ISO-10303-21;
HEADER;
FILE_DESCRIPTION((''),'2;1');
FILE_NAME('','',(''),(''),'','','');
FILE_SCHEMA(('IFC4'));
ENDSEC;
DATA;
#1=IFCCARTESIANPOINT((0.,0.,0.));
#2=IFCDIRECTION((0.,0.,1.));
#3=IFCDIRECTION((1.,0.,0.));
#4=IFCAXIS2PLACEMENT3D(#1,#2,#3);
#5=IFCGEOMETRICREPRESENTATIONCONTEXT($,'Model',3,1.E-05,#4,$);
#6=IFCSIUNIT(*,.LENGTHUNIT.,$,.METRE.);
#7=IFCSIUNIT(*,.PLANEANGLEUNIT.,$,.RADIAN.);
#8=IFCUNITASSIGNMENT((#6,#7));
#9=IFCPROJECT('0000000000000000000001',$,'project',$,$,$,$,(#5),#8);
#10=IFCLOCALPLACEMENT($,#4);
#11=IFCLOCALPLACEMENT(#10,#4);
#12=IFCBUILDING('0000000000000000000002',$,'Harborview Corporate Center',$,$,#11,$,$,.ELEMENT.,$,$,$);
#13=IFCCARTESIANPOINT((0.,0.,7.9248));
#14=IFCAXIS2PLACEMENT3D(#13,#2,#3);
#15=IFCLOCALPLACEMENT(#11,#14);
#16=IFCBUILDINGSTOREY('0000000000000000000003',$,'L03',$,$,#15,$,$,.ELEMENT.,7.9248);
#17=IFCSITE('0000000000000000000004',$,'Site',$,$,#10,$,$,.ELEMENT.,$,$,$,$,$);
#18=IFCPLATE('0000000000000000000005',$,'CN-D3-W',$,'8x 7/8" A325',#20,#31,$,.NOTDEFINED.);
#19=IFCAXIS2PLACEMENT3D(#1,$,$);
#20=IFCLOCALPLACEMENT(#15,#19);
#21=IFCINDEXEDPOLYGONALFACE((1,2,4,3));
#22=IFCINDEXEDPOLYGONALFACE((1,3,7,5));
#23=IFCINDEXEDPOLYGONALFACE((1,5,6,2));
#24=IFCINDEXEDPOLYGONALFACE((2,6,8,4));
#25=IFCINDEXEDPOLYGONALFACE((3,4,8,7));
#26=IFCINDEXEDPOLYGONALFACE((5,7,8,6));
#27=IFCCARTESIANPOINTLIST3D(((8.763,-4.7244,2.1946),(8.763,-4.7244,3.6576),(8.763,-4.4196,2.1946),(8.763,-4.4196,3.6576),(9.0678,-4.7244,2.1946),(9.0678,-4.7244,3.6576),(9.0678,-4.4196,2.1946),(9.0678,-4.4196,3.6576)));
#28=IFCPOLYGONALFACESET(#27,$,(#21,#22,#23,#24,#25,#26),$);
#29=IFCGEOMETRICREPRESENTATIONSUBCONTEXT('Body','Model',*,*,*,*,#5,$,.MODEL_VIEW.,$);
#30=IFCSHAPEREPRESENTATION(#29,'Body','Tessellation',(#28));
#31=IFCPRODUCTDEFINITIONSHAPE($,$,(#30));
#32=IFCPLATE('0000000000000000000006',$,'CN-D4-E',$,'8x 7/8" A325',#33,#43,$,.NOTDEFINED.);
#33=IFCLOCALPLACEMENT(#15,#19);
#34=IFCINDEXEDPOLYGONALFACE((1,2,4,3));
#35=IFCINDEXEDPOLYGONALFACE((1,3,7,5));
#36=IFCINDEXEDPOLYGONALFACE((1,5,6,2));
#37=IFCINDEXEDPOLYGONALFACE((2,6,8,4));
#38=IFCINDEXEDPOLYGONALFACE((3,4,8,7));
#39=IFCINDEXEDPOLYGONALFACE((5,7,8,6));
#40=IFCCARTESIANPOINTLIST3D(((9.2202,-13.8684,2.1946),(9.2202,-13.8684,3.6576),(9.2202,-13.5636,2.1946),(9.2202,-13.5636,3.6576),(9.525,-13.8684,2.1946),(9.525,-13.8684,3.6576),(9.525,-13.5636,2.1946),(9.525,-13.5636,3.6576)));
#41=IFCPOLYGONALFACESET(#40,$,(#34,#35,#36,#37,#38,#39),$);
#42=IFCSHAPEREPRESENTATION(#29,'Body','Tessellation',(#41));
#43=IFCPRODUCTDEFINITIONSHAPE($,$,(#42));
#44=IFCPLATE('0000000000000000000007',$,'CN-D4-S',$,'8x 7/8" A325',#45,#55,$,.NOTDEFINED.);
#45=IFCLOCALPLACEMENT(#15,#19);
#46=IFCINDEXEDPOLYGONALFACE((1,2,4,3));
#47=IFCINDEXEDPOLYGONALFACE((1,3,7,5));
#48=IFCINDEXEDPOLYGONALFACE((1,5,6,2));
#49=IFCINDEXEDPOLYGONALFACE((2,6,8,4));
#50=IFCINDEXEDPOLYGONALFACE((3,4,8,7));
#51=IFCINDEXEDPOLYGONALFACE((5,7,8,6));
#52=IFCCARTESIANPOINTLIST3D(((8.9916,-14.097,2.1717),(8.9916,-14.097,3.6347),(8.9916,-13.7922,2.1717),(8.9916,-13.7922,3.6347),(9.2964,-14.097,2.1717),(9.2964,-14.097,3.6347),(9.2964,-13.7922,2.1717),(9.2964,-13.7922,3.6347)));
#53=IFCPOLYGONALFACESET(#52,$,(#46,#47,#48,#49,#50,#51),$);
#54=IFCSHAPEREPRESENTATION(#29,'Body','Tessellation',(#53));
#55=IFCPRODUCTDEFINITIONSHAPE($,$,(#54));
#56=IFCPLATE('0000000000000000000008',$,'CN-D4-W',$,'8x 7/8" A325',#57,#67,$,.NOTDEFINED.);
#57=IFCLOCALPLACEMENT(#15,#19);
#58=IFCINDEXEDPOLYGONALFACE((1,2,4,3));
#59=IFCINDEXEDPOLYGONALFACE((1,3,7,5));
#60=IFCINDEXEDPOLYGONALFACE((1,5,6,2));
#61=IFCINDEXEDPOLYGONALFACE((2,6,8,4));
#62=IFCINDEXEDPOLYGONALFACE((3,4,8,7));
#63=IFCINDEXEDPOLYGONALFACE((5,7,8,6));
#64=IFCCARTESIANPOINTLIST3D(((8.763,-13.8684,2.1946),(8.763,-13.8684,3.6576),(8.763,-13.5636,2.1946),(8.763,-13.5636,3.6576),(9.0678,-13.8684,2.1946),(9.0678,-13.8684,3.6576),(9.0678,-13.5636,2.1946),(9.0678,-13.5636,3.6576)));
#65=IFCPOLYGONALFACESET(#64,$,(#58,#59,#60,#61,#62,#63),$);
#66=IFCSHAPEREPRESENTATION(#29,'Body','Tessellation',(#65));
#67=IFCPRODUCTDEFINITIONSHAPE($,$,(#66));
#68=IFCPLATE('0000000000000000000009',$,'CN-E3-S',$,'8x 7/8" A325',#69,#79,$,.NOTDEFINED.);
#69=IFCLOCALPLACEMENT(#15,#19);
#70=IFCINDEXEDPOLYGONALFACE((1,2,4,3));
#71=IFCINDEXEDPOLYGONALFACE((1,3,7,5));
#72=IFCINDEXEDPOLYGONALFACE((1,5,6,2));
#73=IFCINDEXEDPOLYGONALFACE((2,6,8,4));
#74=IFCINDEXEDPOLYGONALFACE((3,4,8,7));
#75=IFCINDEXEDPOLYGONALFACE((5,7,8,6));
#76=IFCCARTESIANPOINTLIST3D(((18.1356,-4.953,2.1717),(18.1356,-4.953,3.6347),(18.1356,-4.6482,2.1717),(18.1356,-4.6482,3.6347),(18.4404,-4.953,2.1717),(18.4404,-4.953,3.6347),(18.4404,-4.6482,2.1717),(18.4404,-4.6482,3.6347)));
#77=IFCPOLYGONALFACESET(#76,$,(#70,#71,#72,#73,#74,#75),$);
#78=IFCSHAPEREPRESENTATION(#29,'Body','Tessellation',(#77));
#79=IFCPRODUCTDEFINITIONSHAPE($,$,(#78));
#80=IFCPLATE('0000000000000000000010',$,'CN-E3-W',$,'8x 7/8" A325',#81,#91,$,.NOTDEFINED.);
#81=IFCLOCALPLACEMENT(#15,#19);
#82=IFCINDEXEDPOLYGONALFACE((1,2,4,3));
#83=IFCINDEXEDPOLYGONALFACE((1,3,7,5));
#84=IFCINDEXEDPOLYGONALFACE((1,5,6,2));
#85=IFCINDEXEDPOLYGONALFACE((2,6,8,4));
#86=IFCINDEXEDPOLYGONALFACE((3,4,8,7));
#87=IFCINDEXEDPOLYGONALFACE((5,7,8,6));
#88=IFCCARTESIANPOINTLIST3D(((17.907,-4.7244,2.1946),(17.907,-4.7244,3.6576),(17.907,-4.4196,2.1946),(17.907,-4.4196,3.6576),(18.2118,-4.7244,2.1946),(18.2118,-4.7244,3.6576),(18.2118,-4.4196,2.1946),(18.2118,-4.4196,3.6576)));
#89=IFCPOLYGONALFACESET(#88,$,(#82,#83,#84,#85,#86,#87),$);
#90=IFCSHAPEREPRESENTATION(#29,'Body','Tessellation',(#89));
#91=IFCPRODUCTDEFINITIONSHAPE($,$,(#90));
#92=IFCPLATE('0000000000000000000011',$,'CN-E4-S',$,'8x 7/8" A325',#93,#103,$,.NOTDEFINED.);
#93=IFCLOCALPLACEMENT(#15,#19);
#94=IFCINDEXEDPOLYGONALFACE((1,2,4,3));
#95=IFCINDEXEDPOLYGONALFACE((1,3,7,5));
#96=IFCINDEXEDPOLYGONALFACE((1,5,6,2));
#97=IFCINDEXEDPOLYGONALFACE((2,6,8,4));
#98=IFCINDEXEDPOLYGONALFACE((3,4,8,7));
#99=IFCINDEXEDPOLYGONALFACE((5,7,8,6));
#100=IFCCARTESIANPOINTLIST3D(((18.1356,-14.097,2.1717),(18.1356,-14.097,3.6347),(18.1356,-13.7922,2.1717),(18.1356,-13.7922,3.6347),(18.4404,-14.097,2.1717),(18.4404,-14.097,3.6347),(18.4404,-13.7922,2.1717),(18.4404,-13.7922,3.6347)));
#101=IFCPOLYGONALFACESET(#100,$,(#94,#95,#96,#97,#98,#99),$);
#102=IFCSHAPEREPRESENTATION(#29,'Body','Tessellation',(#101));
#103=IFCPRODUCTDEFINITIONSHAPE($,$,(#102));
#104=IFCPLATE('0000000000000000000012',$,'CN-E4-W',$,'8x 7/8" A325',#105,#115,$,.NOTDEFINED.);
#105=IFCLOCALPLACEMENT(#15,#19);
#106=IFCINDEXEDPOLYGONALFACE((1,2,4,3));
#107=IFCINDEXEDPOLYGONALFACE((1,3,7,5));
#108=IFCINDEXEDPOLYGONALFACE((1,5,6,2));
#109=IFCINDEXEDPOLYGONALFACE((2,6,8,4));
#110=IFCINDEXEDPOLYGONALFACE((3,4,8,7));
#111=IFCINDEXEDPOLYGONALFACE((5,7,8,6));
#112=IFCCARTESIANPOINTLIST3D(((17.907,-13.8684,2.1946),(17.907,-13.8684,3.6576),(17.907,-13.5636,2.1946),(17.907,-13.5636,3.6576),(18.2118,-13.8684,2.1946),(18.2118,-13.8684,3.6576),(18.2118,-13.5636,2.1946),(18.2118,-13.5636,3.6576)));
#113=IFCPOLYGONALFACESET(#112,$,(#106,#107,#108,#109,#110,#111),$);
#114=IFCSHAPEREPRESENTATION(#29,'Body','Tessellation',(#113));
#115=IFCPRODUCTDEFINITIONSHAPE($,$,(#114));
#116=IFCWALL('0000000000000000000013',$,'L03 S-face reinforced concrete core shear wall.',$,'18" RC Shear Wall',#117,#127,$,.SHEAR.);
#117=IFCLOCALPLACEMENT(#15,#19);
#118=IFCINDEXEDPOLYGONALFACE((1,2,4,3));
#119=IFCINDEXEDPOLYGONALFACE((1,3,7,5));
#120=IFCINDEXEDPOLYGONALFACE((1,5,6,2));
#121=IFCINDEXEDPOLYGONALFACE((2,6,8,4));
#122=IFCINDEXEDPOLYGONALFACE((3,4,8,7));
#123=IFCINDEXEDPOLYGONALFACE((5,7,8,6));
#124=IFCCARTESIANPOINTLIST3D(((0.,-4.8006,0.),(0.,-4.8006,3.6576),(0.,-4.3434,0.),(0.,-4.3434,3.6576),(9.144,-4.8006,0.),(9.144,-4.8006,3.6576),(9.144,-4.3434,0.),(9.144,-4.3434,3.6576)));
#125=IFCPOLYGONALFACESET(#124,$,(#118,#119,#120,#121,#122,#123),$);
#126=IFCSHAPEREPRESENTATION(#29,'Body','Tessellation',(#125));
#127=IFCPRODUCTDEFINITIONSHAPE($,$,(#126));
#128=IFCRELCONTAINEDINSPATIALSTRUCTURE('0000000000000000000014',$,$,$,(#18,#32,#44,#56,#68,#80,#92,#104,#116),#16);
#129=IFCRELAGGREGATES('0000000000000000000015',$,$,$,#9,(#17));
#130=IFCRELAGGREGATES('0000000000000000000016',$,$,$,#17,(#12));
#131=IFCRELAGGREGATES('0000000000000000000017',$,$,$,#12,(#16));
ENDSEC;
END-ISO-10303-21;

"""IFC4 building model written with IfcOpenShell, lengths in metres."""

from ifc_helpers import new_model, si_unit, frame, origin_with_axes, place, context, subcontext, project, spatial, rectangle, extrude, element, save


model = new_model("IFC4")

# Units and contexts
model_context = context("Model", 3, precision=1e-05, world=origin_with_axes())
body_context = subcontext(model_context, "Body", "Model", "MODEL_VIEW")
ifc_project = project(units=[si_unit("LENGTHUNIT", "METRE"), si_unit("PLANEANGLEUNIT", "RADIAN")], contexts=[model_context])

# Site, building, storey
site_placement = place(None, origin_with_axes())
site = spatial("IfcSite", under=ifc_project, at=site_placement, Name="Site", CompositionType="ELEMENT")
building_placement = place(site_placement, origin_with_axes())
building = spatial("IfcBuilding", under=site, at=building_placement, Name="Harborview Corporate Center", CompositionType="ELEMENT")
storey_placement = place(building_placement, frame((0.0, 0.0, 7.9248), z_axis=(0.0, 0.0, 1.0), x_axis=(1.0, 0.0, 0.0)))
storey = spatial("IfcBuildingStorey", under=building, at=storey_placement, Name="L03", CompositionType="ELEMENT", Elevation=7.9248)

# Plates
for number, where, z_axis, x_axis, name in (
    (1, (8.9154, -4.572, 2.1946), (0.0, 0.0, 1.0), (1.0, 0.0, 0.0), "CN-D3-W"),
    (2, (9.3726, -13.716, 2.1946), (0.0, 0.0, 1.0), (1.0, 0.0, 0.0), "CN-D4-E"),
    (3, (9.144, -13.9446, 2.1717), (0.0, 0.0, 1.0), (1.0, 0.0, 0.0), "CN-D4-S"),
    (4, (8.9154, -13.716, 2.1946), (0.0, 0.0, 1.0), (1.0, 0.0, 0.0), "CN-D4-W"),
    (5, (18.288, -4.8006, 2.1717), (0.0, 0.0, 1.0), (1.0, 0.0, 0.0), "CN-E3-S"),
    (6, (18.0594, -4.572, 2.1946), (0.0, 0.0, 1.0), (1.0, 0.0, 0.0), "CN-E3-W"),
    (7, (18.288, -13.9446, 2.1717), (0.0, 0.0, 1.0), (1.0, 0.0, 0.0), "CN-E4-S"),
    (8, (18.0594, -13.716, 2.1946), (0.0, 0.0, 1.0), (1.0, 0.0, 0.0), "CN-E4-W"),
):
    element("IfcPlate", number, at=place(storey_placement, frame(where, z_axis=z_axis, x_axis=x_axis)), inside=storey, Name=name, ObjectType="8x 7/8\" A325", PredefinedType="NOTDEFINED", context=body_context, shape_type="SweptSolid", body=[
        extrude(rectangle(XDim=0.3048, YDim=0.3048), origin_with_axes(), (0.0, 0.0, 1.0), 1.463),
    ])

# Wall
wall_placement = place(storey_placement, frame((4.572, -4.572, 0.0), z_axis=(0.0, 0.0, 1.0), x_axis=(1.0, 0.0, 0.0)))
element("IfcWall", 9, at=wall_placement, inside=storey, Name="L03 S-face reinforced concrete core shear wall.", ObjectType="18\" RC Shear Wall", PredefinedType="SHEAR", context=body_context, shape_type="SweptSolid", body=[
    extrude(rectangle(XDim=9.144, YDim=0.4572), origin_with_axes(), (0.0, 0.0, 1.0), 3.6576),
])

save(model, "model.ifc")
